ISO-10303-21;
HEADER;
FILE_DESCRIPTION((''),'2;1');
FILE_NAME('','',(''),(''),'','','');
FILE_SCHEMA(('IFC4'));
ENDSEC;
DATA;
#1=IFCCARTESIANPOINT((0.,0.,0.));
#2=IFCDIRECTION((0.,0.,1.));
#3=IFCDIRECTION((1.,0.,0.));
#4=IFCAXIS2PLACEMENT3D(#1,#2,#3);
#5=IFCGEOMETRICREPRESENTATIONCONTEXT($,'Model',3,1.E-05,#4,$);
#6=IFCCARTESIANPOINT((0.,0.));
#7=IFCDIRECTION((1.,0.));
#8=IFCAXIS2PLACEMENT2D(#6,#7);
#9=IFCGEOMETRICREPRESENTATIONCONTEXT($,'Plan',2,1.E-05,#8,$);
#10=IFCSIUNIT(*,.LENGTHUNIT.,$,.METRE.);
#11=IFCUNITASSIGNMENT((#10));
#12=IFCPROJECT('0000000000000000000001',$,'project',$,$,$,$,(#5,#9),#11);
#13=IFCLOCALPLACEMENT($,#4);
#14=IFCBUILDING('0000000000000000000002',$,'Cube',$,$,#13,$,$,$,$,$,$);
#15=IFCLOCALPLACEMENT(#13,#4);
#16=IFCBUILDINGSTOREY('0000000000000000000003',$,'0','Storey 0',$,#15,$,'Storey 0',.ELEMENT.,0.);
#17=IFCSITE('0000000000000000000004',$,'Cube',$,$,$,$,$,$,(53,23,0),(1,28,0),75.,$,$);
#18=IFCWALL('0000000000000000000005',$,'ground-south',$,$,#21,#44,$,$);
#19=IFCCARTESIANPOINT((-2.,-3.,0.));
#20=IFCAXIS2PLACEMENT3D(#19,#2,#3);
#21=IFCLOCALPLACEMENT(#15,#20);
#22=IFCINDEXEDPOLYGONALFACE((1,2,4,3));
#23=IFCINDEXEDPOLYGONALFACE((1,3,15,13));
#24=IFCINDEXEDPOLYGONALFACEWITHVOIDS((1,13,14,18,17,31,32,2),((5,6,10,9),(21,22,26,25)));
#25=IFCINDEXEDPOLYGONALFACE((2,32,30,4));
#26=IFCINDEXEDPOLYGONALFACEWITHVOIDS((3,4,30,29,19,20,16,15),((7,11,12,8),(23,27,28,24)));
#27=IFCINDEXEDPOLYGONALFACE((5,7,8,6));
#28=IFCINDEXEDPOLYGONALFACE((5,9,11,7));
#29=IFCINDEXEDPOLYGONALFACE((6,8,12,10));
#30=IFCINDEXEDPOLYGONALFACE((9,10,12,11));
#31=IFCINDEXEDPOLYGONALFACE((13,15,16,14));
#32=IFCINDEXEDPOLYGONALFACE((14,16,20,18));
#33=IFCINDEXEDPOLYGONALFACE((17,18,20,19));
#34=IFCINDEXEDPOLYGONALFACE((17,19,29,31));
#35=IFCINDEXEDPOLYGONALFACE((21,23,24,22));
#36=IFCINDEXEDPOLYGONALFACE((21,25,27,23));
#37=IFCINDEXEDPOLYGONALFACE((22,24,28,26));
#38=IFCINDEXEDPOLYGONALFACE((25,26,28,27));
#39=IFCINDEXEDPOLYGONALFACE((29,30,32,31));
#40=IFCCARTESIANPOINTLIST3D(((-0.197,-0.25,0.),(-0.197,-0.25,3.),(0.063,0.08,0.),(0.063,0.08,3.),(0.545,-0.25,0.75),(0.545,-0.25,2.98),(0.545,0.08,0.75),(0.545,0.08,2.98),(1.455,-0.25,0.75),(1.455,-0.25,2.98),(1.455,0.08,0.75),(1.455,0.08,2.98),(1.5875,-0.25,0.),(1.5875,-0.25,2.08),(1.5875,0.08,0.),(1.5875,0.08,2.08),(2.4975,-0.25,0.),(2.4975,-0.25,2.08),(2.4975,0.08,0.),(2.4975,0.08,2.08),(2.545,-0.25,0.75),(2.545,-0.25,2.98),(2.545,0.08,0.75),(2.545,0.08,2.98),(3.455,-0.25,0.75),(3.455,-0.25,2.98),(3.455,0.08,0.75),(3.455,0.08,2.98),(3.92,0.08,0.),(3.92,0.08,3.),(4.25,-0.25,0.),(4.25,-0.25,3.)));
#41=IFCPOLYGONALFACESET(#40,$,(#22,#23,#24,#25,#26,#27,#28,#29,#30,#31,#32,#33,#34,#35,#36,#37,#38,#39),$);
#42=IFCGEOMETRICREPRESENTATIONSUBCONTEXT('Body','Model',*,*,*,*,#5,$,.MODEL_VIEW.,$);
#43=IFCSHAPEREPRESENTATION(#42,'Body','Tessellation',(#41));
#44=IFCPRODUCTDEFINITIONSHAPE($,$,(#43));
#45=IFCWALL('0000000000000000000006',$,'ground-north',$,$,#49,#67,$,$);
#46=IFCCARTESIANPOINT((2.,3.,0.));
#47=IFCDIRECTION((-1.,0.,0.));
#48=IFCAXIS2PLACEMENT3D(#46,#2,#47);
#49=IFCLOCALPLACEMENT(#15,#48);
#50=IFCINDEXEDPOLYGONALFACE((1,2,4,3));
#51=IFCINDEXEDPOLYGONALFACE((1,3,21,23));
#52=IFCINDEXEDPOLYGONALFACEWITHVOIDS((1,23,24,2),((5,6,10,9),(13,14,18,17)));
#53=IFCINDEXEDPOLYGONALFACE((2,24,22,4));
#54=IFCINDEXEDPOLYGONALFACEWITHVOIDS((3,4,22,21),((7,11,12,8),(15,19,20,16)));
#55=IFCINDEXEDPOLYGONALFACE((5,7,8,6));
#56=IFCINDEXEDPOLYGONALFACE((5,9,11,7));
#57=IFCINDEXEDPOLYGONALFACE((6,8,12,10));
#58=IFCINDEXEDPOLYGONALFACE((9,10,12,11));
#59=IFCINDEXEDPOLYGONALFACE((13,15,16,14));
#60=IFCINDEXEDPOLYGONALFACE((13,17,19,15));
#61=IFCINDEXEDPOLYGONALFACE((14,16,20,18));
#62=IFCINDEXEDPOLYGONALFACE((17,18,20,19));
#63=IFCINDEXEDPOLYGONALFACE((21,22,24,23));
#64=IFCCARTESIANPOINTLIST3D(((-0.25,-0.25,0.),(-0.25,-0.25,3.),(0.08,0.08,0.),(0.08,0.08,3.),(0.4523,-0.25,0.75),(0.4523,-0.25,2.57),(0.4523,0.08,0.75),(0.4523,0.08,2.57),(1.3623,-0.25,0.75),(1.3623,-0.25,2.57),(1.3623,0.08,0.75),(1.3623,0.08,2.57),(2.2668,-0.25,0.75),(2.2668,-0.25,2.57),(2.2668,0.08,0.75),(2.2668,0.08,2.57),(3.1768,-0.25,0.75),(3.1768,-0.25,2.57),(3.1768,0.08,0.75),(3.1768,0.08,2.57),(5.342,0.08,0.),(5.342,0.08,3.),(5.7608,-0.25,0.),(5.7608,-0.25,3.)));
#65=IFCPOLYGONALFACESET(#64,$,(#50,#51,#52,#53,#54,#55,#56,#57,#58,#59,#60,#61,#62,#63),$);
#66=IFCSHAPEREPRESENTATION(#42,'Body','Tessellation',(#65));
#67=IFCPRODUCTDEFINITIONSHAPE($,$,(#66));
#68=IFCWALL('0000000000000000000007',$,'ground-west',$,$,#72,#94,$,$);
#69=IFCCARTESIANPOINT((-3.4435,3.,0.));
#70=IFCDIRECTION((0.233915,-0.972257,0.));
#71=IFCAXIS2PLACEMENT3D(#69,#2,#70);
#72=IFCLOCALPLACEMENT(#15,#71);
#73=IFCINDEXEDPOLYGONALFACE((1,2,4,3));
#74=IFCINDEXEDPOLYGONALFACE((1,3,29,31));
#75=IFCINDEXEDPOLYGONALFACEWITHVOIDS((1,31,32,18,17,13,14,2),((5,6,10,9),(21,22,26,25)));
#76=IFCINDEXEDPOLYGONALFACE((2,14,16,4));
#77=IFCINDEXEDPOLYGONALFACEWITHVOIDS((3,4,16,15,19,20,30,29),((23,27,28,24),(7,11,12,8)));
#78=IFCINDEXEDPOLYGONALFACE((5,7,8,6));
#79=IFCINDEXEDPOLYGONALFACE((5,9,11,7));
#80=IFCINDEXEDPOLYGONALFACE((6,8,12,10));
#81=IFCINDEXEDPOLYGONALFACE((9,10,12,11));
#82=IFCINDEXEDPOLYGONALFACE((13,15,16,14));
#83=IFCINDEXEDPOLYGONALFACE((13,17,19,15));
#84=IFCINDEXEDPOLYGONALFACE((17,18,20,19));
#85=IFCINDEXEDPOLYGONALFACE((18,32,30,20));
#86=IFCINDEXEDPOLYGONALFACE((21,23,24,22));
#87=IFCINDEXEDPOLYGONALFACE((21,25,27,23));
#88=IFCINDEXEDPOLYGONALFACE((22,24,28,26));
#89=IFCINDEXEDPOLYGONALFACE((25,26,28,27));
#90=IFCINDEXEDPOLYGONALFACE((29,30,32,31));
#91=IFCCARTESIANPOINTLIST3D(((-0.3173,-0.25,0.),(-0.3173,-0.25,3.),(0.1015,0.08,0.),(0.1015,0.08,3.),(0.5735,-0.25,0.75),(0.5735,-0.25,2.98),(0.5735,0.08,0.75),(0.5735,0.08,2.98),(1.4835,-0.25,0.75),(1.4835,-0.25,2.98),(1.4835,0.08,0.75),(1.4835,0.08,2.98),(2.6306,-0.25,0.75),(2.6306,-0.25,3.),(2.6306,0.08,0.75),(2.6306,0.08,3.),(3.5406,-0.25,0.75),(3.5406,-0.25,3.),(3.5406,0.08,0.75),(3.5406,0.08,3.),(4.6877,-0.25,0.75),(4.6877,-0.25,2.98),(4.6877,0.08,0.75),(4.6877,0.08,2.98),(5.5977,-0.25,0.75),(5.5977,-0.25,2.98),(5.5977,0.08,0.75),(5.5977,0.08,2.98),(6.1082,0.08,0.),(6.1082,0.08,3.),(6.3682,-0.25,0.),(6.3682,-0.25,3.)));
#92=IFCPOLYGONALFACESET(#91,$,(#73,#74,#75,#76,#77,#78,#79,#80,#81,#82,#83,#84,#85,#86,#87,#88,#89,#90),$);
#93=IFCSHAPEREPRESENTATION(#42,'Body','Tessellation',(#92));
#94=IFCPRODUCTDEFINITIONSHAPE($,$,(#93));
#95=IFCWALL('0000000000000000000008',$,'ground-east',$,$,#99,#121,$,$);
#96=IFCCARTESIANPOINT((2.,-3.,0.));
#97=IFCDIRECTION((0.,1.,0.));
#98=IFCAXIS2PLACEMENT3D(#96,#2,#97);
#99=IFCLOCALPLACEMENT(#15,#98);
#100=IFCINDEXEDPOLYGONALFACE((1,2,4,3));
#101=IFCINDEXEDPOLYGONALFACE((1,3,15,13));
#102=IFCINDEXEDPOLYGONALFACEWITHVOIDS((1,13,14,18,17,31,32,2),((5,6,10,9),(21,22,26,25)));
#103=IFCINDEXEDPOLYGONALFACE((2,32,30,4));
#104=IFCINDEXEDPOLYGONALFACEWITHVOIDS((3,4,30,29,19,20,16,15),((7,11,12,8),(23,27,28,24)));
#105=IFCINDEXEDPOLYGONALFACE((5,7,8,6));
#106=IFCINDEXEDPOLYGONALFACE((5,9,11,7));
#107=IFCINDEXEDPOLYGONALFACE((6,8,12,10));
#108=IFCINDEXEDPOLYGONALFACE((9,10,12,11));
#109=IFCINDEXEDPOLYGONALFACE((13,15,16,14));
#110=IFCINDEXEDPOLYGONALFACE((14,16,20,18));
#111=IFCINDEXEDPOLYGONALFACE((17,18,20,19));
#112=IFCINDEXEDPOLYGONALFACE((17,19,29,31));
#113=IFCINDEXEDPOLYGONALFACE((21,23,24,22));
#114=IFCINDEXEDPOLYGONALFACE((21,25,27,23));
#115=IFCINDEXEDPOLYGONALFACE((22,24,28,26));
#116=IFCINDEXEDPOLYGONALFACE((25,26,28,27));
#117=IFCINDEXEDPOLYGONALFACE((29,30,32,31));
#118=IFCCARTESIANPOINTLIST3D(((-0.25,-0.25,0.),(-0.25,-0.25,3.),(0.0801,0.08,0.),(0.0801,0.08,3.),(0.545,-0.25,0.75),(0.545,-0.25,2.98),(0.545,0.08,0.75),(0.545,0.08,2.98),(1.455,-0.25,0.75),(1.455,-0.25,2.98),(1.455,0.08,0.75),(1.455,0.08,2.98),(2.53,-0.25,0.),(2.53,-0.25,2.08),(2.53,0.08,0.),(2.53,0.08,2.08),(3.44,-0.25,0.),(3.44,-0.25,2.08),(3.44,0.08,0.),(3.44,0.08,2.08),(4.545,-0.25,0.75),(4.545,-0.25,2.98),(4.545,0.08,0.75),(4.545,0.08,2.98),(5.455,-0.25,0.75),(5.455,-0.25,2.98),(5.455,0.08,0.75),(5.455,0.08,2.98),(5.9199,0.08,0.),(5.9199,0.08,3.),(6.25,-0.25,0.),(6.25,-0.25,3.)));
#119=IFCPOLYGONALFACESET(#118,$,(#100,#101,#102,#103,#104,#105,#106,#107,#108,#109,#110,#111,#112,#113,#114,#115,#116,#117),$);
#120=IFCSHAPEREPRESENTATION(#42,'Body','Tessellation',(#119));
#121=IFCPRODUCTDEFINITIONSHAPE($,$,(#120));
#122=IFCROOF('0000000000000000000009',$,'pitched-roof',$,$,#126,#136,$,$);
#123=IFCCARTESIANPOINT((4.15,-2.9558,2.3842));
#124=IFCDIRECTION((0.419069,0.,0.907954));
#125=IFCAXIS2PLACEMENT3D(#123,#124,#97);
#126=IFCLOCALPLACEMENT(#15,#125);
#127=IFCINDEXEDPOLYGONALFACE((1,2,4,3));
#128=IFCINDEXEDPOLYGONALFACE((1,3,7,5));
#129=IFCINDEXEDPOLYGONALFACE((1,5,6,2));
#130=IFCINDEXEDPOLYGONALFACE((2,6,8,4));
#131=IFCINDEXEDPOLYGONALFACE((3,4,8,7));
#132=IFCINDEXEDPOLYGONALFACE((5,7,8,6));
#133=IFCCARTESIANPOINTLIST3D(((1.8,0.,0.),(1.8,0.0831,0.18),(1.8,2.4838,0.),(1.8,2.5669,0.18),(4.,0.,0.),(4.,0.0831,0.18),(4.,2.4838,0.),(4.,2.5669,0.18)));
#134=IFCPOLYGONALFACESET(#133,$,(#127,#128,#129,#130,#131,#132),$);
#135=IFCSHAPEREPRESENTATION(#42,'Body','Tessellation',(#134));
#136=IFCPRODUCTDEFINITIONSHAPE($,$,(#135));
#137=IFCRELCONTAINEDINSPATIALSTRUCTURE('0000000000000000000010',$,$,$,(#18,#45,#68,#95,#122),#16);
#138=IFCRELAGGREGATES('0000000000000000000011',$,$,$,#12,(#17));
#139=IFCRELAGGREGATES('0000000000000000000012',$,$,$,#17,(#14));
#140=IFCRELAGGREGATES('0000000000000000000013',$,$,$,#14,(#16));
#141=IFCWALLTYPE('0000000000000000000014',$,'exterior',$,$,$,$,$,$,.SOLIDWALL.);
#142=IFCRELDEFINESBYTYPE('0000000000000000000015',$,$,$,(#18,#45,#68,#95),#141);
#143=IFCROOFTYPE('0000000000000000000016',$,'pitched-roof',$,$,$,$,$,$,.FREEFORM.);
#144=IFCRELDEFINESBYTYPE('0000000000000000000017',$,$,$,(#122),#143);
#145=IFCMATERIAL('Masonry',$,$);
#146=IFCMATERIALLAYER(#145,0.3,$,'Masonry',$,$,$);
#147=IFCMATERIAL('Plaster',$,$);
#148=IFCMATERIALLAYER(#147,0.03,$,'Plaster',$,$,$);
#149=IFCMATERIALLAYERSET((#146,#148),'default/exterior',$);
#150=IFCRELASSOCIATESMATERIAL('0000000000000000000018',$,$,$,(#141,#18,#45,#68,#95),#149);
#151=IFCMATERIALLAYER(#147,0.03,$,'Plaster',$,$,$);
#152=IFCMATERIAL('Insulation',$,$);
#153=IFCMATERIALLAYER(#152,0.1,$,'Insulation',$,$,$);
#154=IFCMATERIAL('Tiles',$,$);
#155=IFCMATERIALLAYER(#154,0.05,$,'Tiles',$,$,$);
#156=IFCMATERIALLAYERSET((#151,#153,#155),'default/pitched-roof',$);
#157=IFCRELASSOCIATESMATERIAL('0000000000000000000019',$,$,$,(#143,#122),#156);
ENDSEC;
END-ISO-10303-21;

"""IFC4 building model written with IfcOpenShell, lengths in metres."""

from ifc_helpers import new_model, si_unit, frame, origin_with_axes, origin_2d_with_axis, place, context, subcontext, project, spatial, line, indexed_curve, outline, extrude, material, layer, layer_set, layer_usage, type_object, element, save


model = new_model("IFC4")

# Units and contexts
model_context = context("Model", 3, precision=1e-05, world=origin_with_axes())
plan_context = context("Plan", 2, precision=1e-05, world=origin_2d_with_axis())
body_context = subcontext(model_context, "Body", "Model", "MODEL_VIEW")
ifc_project = project(units=[si_unit("LENGTHUNIT", "METRE")], contexts=[model_context, plan_context])

# Site, building, storey
site = spatial("IfcSite", under=ifc_project, Name="Cube", RefLatitude=(53, 23, 0), RefLongitude=(1, 28, 0), RefElevation=75.0)
building_placement = place(None, origin_with_axes())
building = spatial("IfcBuilding", under=site, at=building_placement, Name="Cube")
storey_placement = place(building_placement, origin_with_axes())
storey = spatial("IfcBuildingStorey", under=building, at=storey_placement, Name="0", Description="Storey 0", LongName="Storey 0", CompositionType="ELEMENT", Elevation=0.0)

# Shared definitions
ifc_material_1 = material(Name="Masonry")
ifc_layer_1 = layer(ifc_material_1, 0.3, Name="Masonry")
ifc_material_2 = material(Name="Plaster")
ifc_layer_2 = layer(ifc_material_2, 0.03, Name="Plaster")
ifc_layer_set_1 = layer_set([ifc_layer_1, ifc_layer_2], Name="default/exterior")
wall_type = type_object("IfcWallType", Name="exterior", PredefinedType="SOLIDWALL", material=ifc_layer_set_1)

# Walls, openings
ifc_layer_usage_1 = layer_usage(ifc_layer_set_1, "AXIS2", "POSITIVE", 0.0)
wall_1_placement = place(storey_placement, frame((-2.0, -3.0, 0.0), z_axis=(0.0, 0.0, 1.0), x_axis=(1.0, 0.0, 0.0)))
wall_1 = element("IfcWall", 1, at=wall_1_placement, inside=storey, type_object=wall_type, material=ifc_layer_usage_1, Name="ground-south", context=body_context, shape_type="SweptSolid", body=[
    extrude(outline(indexed_curve([(0.063, 0.08), (-0.197, -0.25), (4.25, -0.25), (3.92, 0.08)], segments=[line(1, 2, 3, 4, 1)])), origin_with_axes(), (0.0, 0.0, 1.0), 3.0),
])
opening_1_placement = place(wall_1_placement, frame((0.545, -0.25, 0.75), z_axis=(0.0, 0.0, 1.0), x_axis=(1.0, 0.0, 0.0)))
element("IfcOpeningElement", 2, at=opening_1_placement, cuts=wall_1, PredefinedType="OPENING", context=body_context, shape_type="SweptSolid", body=[
    extrude(outline(indexed_curve([(0.0, 0.0), (0.0, 0.5), (0.91, 0.5), (0.91, 0.0), (0.0, 0.0)], self_intersect=False)), origin_with_axes(), (0.0, 0.0, 1.0), 2.23),
])
opening_2_placement = place(wall_1_placement, frame((2.545, -0.25, 0.75), z_axis=(0.0, 0.0, 1.0), x_axis=(1.0, 0.0, 0.0)))
element("IfcOpeningElement", 3, at=opening_2_placement, cuts=wall_1, PredefinedType="OPENING", context=body_context, shape_type="SweptSolid", body=[
    extrude(outline(indexed_curve([(0.0, 0.0), (0.0, 0.5), (0.91, 0.5), (0.91, 0.0), (0.0, 0.0)], self_intersect=False)), origin_with_axes(), (0.0, 0.0, 1.0), 2.23),
])
opening_3_placement = place(wall_1_placement, frame((1.5875, -0.25, 0.0), z_axis=(0.0, 0.0, 1.0), x_axis=(1.0, 0.0, 0.0)))
element("IfcOpeningElement", 4, at=opening_3_placement, cuts=wall_1, PredefinedType="OPENING", context=body_context, shape_type="SweptSolid", body=[
    extrude(outline(indexed_curve([(0.0, 0.0), (0.0, 0.5), (0.91, 0.5), (0.91, 0.0), (0.0, 0.0)], self_intersect=False)), origin_with_axes(), (0.0, 0.0, 1.0), 2.08),
])
ifc_layer_usage_2 = layer_usage(ifc_layer_set_1, "AXIS2", "POSITIVE", 0.0)
wall_2_placement = place(storey_placement, frame((2.0, 3.0, 0.0), z_axis=(0.0, 0.0, 1.0), x_axis=(-1.0, 0.0, 0.0)))
wall_2 = element("IfcWall", 5, at=wall_2_placement, inside=storey, type_object=wall_type, material=ifc_layer_usage_2, Name="ground-north", context=body_context, shape_type="SweptSolid", body=[
    extrude(outline(indexed_curve([(0.08, 0.08), (-0.25, -0.25), (5.7608, -0.25), (5.342, 0.08)], segments=[line(1, 2, 3, 4, 1)])), origin_with_axes(), (0.0, 0.0, 1.0), 3.0),
])
opening_4_placement = place(wall_2_placement, frame((2.2668, -0.25, 0.75), z_axis=(0.0, 0.0, 1.0), x_axis=(1.0, 0.0, 0.0)))
element("IfcOpeningElement", 6, at=opening_4_placement, cuts=wall_2, PredefinedType="OPENING", context=body_context, shape_type="SweptSolid", body=[
    extrude(outline(indexed_curve([(0.0, 0.0), (0.0, 0.5), (0.91, 0.5), (0.91, 0.0), (0.0, 0.0)], self_intersect=False)), origin_with_axes(), (0.0, 0.0, 1.0), 1.82),
])
opening_5_placement = place(wall_2_placement, frame((0.4523, -0.25, 0.75), z_axis=(0.0, 0.0, 1.0), x_axis=(1.0, 0.0, 0.0)))
element("IfcOpeningElement", 7, at=opening_5_placement, cuts=wall_2, PredefinedType="OPENING", context=body_context, shape_type="SweptSolid", body=[
    extrude(outline(indexed_curve([(0.0, 0.0), (0.0, 0.5), (0.91, 0.5), (0.91, 0.0), (0.0, 0.0)], self_intersect=False)), origin_with_axes(), (0.0, 0.0, 1.0), 1.82),
])
ifc_layer_usage_3 = layer_usage(ifc_layer_set_1, "AXIS2", "POSITIVE", 0.0)
wall_3_placement = place(storey_placement, frame((-3.4435, 3.0, 0.0), z_axis=(0.0, 0.0, 1.0), x_axis=(0.233915, -0.972257, 0.0)))
wall_3 = element("IfcWall", 8, at=wall_3_placement, inside=storey, type_object=wall_type, material=ifc_layer_usage_3, Name="ground-west", context=body_context, shape_type="SweptSolid", body=[
    extrude(outline(indexed_curve([(0.1015, 0.08), (-0.3173, -0.25), (6.3682, -0.25), (6.1082, 0.08)], segments=[line(1, 2, 3, 4, 1)])), origin_with_axes(), (0.0, 0.0, 1.0), 3.0),
])
opening_6_placement = place(wall_3_placement, frame((0.5735, -0.25, 0.75), z_axis=(0.0, 0.0, 1.0), x_axis=(1.0, 0.0, 0.0)))
element("IfcOpeningElement", 9, at=opening_6_placement, cuts=wall_3, PredefinedType="OPENING", context=body_context, shape_type="SweptSolid", body=[
    extrude(outline(indexed_curve([(0.0, 0.0), (0.0, 0.5), (0.91, 0.5), (0.91, 0.0), (0.0, 0.0)], self_intersect=False)), origin_with_axes(), (0.0, 0.0, 1.0), 2.23),
])
opening_7_placement = place(wall_3_placement, frame((2.6306, -0.25, 0.75), z_axis=(0.0, 0.0, 1.0), x_axis=(1.0, 0.0, 0.0)))
element("IfcOpeningElement", 10, at=opening_7_placement, cuts=wall_3, PredefinedType="OPENING", context=body_context, shape_type="SweptSolid", body=[
    extrude(outline(indexed_curve([(0.0, 0.0), (0.0, 0.5), (0.91, 0.5), (0.91, 0.0), (0.0, 0.0)], self_intersect=False)), origin_with_axes(), (0.0, 0.0, 1.0), 2.65),
])
opening_8_placement = place(wall_3_placement, frame((4.6877, -0.25, 0.75), z_axis=(0.0, 0.0, 1.0), x_axis=(1.0, 0.0, 0.0)))
element("IfcOpeningElement", 11, at=opening_8_placement, cuts=wall_3, PredefinedType="OPENING", context=body_context, shape_type="SweptSolid", body=[
    extrude(outline(indexed_curve([(0.0, 0.0), (0.0, 0.5), (0.91, 0.5), (0.91, 0.0), (0.0, 0.0)], self_intersect=False)), origin_with_axes(), (0.0, 0.0, 1.0), 2.23),
])
ifc_layer_usage_4 = layer_usage(ifc_layer_set_1, "AXIS2", "POSITIVE", 0.0)
wall_4_placement = place(storey_placement, frame((2.0, -3.0, 0.0), z_axis=(0.0, 0.0, 1.0), x_axis=(0.0, 1.0, 0.0)))
wall_4 = element("IfcWall", 12, at=wall_4_placement, inside=storey, type_object=wall_type, material=ifc_layer_usage_4, Name="ground-east", context=body_context, shape_type="SweptSolid", body=[
    extrude(outline(indexed_curve([(0.0801, 0.08), (-0.25, -0.25), (6.25, -0.25), (5.9199, 0.08)], segments=[line(1, 2, 3, 4, 1)])), origin_with_axes(), (0.0, 0.0, 1.0), 3.0),
])
opening_9_placement = place(wall_4_placement, frame((2.53, -0.25, 0.0), z_axis=(0.0, 0.0, 1.0), x_axis=(1.0, 0.0, 0.0)))
element("IfcOpeningElement", 13, at=opening_9_placement, cuts=wall_4, PredefinedType="OPENING", context=body_context, shape_type="SweptSolid", body=[
    extrude(outline(indexed_curve([(0.0, 0.0), (0.0, 0.5), (0.91, 0.5), (0.91, 0.0), (0.0, 0.0)], self_intersect=False)), origin_with_axes(), (0.0, 0.0, 1.0), 2.08),
])
opening_10_placement = place(wall_4_placement, frame((0.545, -0.25, 0.75), z_axis=(0.0, 0.0, 1.0), x_axis=(1.0, 0.0, 0.0)))
element("IfcOpeningElement", 14, at=opening_10_placement, cuts=wall_4, PredefinedType="OPENING", context=body_context, shape_type="SweptSolid", body=[
    extrude(outline(indexed_curve([(0.0, 0.0), (0.0, 0.5), (0.91, 0.5), (0.91, 0.0), (0.0, 0.0)], self_intersect=False)), origin_with_axes(), (0.0, 0.0, 1.0), 2.23),
])
opening_11_placement = place(wall_4_placement, frame((4.545, -0.25, 0.75), z_axis=(0.0, 0.0, 1.0), x_axis=(1.0, 0.0, 0.0)))
element("IfcOpeningElement", 15, at=opening_11_placement, cuts=wall_4, PredefinedType="OPENING", context=body_context, shape_type="SweptSolid", body=[
    extrude(outline(indexed_curve([(0.0, 0.0), (0.0, 0.5), (0.91, 0.5), (0.91, 0.0), (0.0, 0.0)], self_intersect=False)), origin_with_axes(), (0.0, 0.0, 1.0), 2.23),
])

# Roof
ifc_layer_3 = layer(ifc_material_2, 0.03, Name="Plaster")
ifc_material_3 = material(Name="Insulation")
ifc_layer_4 = layer(ifc_material_3, 0.1, Name="Insulation")
ifc_material_4 = material(Name="Tiles")
ifc_layer_5 = layer(ifc_material_4, 0.05, Name="Tiles")
ifc_layer_set_2 = layer_set([ifc_layer_3, ifc_layer_4, ifc_layer_5], Name="default/pitched-roof")
ifc_layer_usage_5 = layer_usage(ifc_layer_set_2, "AXIS3", "POSITIVE", 0.0)
roof_type = type_object("IfcRoofType", Name="pitched-roof", PredefinedType="FREEFORM", material=ifc_layer_set_2)
roof_placement = place(storey_placement, frame((4.15, -2.9558, 2.3842), z_axis=(0.419069, 0.0, 0.907954), x_axis=(0.0, 1.0, 0.0)))
element("IfcRoof", 16, at=roof_placement, inside=storey, type_object=roof_type, material=ifc_layer_usage_5, Name="pitched-roof", context=body_context, shape_type="SweptSolid", body=[
    extrude(outline(indexed_curve([(4.0, 2.4838), (4.0, 0.0), (1.8, 0.0), (1.8, 2.4838)])), frame((0.0, 0.0, 0.0), z_axis=(0.0, 0.0, 1.0), x_axis=(1.0, 0.0, 0.0)), (0.0, 0.419069, 0.907954), 0.1982),
])

save(model, "model.ifc")
